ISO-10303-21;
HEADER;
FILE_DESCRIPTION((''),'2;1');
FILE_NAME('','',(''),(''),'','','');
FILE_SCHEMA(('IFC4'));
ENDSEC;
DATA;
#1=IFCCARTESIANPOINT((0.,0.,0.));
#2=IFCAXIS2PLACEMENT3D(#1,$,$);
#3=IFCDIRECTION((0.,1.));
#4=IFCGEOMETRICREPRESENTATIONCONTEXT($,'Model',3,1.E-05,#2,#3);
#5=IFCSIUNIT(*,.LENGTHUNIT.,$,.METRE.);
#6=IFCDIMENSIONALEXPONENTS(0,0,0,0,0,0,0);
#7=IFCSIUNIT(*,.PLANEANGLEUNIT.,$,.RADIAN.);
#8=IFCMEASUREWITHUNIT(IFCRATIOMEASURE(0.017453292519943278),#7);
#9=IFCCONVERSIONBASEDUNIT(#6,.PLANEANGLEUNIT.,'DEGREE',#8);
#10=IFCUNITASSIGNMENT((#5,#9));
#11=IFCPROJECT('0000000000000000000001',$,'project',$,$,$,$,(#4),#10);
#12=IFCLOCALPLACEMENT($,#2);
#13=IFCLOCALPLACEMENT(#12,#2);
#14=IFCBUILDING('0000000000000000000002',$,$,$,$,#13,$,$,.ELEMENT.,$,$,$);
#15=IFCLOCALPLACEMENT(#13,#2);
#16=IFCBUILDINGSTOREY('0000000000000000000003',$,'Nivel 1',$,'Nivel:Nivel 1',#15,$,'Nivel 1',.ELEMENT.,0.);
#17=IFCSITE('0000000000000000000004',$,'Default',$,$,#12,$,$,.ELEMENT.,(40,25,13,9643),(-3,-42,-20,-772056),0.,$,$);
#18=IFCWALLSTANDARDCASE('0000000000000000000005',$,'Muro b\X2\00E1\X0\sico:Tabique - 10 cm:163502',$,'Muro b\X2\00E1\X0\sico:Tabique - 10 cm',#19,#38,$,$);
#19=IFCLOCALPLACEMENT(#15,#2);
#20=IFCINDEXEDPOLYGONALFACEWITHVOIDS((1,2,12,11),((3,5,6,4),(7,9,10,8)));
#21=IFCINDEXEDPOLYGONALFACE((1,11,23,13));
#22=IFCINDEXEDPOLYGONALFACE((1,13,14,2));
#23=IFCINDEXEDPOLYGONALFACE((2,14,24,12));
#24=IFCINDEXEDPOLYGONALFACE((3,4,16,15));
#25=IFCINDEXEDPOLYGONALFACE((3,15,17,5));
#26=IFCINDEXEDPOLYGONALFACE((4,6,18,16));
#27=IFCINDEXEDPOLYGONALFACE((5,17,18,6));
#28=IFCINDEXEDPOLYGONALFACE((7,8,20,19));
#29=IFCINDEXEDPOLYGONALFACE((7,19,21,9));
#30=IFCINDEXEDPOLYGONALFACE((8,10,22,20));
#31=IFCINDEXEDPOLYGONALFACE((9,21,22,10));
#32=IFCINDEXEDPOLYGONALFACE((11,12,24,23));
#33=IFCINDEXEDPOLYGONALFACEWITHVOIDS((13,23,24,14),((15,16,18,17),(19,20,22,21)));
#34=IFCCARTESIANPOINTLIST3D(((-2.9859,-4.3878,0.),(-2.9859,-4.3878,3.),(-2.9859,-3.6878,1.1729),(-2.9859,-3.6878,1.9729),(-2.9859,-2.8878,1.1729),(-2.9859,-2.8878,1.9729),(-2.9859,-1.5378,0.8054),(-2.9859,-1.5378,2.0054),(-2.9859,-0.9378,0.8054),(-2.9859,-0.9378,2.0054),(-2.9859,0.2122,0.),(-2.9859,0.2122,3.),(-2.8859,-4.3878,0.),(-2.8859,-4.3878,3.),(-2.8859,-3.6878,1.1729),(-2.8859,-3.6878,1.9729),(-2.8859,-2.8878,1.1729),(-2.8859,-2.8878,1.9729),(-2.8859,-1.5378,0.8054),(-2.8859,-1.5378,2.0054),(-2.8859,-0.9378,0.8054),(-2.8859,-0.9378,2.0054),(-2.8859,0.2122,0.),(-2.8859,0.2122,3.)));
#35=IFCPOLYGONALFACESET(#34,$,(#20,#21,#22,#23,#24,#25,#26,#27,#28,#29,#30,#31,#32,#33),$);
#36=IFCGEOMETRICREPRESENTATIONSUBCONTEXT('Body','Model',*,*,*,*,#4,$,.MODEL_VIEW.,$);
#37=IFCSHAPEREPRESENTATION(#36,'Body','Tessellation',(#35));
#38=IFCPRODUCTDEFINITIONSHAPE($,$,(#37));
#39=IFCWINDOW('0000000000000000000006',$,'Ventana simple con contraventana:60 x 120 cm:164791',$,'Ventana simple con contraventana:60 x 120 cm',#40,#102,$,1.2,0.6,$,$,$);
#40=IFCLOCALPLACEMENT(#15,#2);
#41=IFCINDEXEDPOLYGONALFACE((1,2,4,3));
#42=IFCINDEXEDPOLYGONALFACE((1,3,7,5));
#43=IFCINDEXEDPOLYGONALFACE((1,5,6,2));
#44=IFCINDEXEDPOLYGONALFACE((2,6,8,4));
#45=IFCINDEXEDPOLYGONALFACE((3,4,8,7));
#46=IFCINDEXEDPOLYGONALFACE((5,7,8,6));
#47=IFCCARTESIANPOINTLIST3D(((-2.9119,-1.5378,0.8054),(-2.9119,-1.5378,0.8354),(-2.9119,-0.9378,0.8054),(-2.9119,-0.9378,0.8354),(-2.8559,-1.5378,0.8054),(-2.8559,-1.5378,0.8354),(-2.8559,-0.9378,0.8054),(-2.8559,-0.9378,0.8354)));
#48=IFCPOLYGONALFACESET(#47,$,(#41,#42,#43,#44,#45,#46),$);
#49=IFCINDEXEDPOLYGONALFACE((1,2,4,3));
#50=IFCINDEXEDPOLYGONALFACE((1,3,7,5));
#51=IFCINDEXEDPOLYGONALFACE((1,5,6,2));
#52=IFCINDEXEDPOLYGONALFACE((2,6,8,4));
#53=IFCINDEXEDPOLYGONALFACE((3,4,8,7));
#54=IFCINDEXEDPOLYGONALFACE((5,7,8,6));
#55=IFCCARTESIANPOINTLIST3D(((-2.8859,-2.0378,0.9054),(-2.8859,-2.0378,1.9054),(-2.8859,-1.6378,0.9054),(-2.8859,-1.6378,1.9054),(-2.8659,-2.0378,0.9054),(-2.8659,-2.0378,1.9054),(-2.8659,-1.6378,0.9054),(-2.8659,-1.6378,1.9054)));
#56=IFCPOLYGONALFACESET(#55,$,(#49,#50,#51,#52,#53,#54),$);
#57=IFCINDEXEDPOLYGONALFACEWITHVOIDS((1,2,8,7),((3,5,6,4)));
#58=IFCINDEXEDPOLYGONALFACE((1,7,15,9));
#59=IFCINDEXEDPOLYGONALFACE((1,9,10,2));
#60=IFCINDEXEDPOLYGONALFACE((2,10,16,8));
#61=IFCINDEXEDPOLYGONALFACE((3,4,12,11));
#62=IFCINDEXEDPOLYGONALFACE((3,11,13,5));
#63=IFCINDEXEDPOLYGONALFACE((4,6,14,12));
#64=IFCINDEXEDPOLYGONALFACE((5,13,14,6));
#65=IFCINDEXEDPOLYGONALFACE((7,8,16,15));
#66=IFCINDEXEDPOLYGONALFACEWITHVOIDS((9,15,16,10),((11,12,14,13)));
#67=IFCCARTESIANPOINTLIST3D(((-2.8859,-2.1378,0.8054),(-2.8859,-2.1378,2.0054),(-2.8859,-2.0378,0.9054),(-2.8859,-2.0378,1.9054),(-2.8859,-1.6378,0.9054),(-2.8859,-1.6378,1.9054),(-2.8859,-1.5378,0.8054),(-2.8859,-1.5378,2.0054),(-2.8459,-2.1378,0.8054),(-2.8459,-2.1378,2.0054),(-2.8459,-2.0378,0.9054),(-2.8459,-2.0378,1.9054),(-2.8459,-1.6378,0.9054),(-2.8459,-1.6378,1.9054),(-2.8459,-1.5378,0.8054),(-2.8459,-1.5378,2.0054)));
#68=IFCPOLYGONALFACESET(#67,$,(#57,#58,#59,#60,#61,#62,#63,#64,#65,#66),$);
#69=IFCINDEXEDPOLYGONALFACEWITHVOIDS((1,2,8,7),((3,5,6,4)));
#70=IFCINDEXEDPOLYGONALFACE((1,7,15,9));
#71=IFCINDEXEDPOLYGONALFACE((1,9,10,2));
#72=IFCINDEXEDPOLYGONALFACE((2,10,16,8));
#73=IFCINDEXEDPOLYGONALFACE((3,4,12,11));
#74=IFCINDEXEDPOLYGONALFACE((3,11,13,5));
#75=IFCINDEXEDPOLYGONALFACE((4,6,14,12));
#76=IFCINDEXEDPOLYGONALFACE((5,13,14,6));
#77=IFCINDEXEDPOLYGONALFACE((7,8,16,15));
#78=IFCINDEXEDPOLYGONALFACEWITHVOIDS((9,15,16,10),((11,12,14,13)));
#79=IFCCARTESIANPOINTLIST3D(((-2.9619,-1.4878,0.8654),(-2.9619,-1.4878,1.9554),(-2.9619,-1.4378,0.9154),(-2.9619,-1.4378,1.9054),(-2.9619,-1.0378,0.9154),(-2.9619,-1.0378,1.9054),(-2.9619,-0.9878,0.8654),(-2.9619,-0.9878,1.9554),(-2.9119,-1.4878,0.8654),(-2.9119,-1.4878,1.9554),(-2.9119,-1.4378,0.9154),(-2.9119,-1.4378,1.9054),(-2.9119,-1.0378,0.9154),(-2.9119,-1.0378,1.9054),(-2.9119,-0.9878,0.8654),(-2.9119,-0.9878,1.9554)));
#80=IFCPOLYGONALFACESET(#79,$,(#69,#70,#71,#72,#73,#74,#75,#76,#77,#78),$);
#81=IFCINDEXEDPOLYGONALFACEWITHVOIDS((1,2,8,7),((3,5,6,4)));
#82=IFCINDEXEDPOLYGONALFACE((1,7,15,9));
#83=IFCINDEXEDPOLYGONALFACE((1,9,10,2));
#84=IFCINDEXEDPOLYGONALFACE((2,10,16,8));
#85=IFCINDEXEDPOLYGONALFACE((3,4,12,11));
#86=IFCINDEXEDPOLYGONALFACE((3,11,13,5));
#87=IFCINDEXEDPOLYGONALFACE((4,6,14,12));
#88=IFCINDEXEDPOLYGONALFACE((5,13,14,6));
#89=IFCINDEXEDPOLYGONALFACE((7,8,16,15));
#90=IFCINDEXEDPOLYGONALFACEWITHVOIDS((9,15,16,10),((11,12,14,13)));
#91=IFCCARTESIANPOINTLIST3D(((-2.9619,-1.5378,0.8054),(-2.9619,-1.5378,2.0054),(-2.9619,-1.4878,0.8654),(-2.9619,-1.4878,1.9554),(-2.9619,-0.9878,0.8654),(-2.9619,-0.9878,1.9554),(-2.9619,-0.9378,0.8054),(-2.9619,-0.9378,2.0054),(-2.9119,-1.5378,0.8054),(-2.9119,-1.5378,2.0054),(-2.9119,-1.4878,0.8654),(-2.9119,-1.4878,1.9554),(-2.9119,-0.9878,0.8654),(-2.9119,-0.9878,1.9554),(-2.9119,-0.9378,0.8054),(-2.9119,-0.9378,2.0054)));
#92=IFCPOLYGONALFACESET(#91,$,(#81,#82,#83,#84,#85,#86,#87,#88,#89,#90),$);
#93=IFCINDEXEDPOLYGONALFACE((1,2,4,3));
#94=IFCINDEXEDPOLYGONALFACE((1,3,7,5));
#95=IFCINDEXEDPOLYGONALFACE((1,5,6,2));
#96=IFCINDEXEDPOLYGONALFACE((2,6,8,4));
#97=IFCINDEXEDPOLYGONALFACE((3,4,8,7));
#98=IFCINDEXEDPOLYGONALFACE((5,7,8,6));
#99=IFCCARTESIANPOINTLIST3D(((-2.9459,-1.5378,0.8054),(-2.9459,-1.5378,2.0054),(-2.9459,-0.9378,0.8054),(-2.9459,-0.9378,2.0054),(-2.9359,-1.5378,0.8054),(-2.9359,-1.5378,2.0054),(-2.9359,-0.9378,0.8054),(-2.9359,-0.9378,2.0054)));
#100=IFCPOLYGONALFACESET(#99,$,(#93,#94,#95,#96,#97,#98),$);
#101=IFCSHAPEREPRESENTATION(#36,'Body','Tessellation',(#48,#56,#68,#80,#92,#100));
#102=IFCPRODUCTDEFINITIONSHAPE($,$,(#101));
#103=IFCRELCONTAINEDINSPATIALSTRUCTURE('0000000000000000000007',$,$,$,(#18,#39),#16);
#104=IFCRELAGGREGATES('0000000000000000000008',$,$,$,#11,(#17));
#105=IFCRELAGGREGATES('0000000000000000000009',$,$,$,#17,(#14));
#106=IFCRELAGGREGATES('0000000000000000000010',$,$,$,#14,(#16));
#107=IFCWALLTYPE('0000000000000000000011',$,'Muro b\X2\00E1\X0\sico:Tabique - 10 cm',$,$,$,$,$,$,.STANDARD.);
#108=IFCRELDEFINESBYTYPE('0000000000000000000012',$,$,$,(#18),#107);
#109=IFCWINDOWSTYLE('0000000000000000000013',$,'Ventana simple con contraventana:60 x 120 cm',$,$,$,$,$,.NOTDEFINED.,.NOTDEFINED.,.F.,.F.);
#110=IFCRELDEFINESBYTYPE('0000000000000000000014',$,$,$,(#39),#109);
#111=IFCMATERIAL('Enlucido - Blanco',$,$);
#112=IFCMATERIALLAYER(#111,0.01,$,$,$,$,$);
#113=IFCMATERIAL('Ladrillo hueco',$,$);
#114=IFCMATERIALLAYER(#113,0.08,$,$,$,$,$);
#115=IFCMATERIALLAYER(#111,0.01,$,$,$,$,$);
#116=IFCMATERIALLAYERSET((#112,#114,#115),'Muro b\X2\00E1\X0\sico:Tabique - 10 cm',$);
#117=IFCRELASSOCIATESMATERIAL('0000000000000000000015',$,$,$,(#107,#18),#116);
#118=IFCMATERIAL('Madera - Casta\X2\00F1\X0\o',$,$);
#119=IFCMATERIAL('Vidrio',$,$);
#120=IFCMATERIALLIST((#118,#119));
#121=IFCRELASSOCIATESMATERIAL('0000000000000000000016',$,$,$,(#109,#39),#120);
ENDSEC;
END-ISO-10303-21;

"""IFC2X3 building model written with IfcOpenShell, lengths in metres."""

from ifc_helpers import new_model, entity, si_unit, converted_unit, direction, frame, frame_2d, origin, origin_2d_with_axis, place, context, subcontext, project, spatial, polyline, rectangle, outline, extrude, source, transform, mapped, material, material_list, layer, layer_set, layer_usage, type_object, type_shapes, element, fill, save


model = new_model("IFC2X3")

# Units and contexts
model_context = context("Model", 3, precision=1e-05, world=origin(), true_north=direction((0.0, 1.0)))
body_context = subcontext(model_context, "Body", "Model", "MODEL_VIEW")
ifc_project = project(units=[si_unit("LENGTHUNIT", "METRE"), converted_unit("PLANEANGLEUNIT", "DEGREE", entity("IfcRatioMeasure", 0.017453292519943278), si_unit("PLANEANGLEUNIT", "RADIAN"), dimensions=[0, 0, 0, 0, 0, 0, 0])], contexts=[model_context])

# Site, building, storey
site_placement = place(None, origin())
site = spatial("IfcSite", under=ifc_project, at=site_placement, Name="Default", CompositionType="ELEMENT", RefLatitude=(40, 25, 13, 9643), RefLongitude=(-3, -42, -20, -772056), RefElevation=0.0)
building_placement = place(site_placement, origin())
building = spatial("IfcBuilding", under=site, at=building_placement, CompositionType="ELEMENT")
storey_placement = place(building_placement, origin())
storey = spatial("IfcBuildingStorey", under=building, at=storey_placement, Name="Nivel 1", ObjectType="Nivel:Nivel 1", LongName="Nivel 1", CompositionType="ELEMENT", Elevation=0.0)

# Shared definitions
ifc_material_1 = material(Name="Ladrillo hueco")
ifc_material_2 = material(Name="Enlucido - Blanco")

# Wall, openings, window
ifc_layer_1 = layer(ifc_material_2, 0.01)
ifc_layer_2 = layer(ifc_material_1, 0.08)
ifc_layer_3 = layer(ifc_material_2, 0.01)
ifc_layer_set_1 = layer_set([ifc_layer_1, ifc_layer_2, ifc_layer_3], Name="Muro básico:Tabique - 10 cm")
ifc_layer_usage_1 = layer_usage(ifc_layer_set_1, "AXIS2", "NEGATIVE", 0.05)
wall_type_1 = type_object("IfcWallType", Name="Muro básico:Tabique - 10 cm", PredefinedType="STANDARD", material=ifc_layer_set_1)
wall_1_placement = place(storey_placement, frame((-2.9359, 0.2122, 0.0), z_axis=(0.0, 0.0, 1.0), x_axis=(0.0, -1.0, 0.0)))
wall_1 = element("IfcWallStandardCase", 1, at=wall_1_placement, inside=storey, type_object=wall_type_1, material=ifc_layer_usage_1, Name="Muro básico:Tabique - 10 cm:163502", ObjectType="Muro básico:Tabique - 10 cm", context=body_context, shape_type="SweptSolid", body=[
    extrude(rectangle(XDim=4.6, YDim=0.1, at=frame_2d((2.3, 0.0), x_axis=(-1.0, 0.0))), origin(), (0.0, 0.0, 1.0), 3.0),
])
opening_1_placement = place(wall_1_placement, frame((3.1, -0.05, 1.1729)))
element("IfcOpeningElement", 2, at=opening_1_placement, cuts=wall_1, ObjectType="Opening", context=body_context, shape_type="SweptSolid", body=[
    extrude(rectangle(XDim=0.8, YDim=0.8, at=frame_2d((0.4, 0.4), x_axis=(1.0, 0.0))), frame((0.0, 0.0, 0.0), z_axis=(0.0, 1.0, 0.0), x_axis=(0.0, 0.0, 1.0)), (0.0, 0.0, 1.0), 0.1),
])
opening_2_placement = place(wall_1_placement, frame((1.15, -0.05, 0.8054)))
opening_2 = element("IfcOpeningElement", 3, at=opening_2_placement, cuts=wall_1, ObjectType="Opening", context=body_context, shape_type="SweptSolid", body=[
    extrude(rectangle(XDim=1.2, YDim=0.6, at=frame_2d((0.6, 0.3), x_axis=(1.0, 0.0))), frame((0.0, 0.0, 0.0), z_axis=(0.0, 1.0, 0.0), x_axis=(0.0, 0.0, 1.0)), (0.0, 0.0, 1.0), 0.1),
])
ifc_material_3 = material(Name="Madera - Castaño")
ifc_material_4 = material(Name="Vidrio")
ifc_material_list = material_list([ifc_material_3, ifc_material_4])
window_style = type_object("IfcWindowStyle", Name="Ventana simple con contraventana:60 x 120 cm", ConstructionType="NOTDEFINED", OperationType="NOTDEFINED", ParameterTakesPrecedence=False, Sizeable=False, material=ifc_material_list)
shared_shape_1 = source(origin(), body_context, "Body", "SweptSolid", [
    extrude(rectangle(XDim=0.6, YDim=0.056, at=frame_2d((0.0, 0.0), x_axis=(1.0, 0.0))), frame((0.3, 0.102, 0.0)), (0.0, 0.0, 1.0), 0.03),
    extrude(rectangle(XDim=0.02, YDim=0.4, at=frame_2d((0.0, 0.0), x_axis=(1.0, 0.0))), frame((0.9, 0.11, 0.1), z_axis=(0.0, 0.0, 1.0), x_axis=(0.0, 1.0, 0.0)), (0.0, 0.0, 1.0), 1.0),
    extrude(outline(polyline([(-0.6, -0.3), (0.6, -0.3), (0.6, 0.3), (-0.6, 0.3), (-0.6, -0.3)]), holes=[polyline([(-0.5, 0.2), (0.5, 0.2), (0.5, -0.2), (-0.5, -0.2), (-0.5, 0.2)])]), frame((0.9, 0.1, 0.6), z_axis=(0.0, 1.0, 0.0), x_axis=(0.0, 0.0, -1.0)), (0.0, 0.0, 1.0), 0.04),
    extrude(outline(polyline([(-0.545, -0.25), (0.545, -0.25), (0.545, 0.25), (-0.545, 0.25), (-0.545, -0.25)]), holes=[polyline([(-0.495, -0.2), (-0.495, 0.2), (0.495, 0.2), (0.495, -0.2), (-0.495, -0.2)])]), frame((0.3, 0.024, 0.605), z_axis=(0.0, 1.0, 0.0), x_axis=(0.0, 0.0, -1.0)), (0.0, 0.0, 1.0), 0.05),
    extrude(outline(polyline([(-0.3, -0.6), (0.3, -0.6), (0.3, 0.6), (-0.3, 0.6), (-0.3, -0.6)]), holes=[polyline([(-0.25, -0.55), (-0.25, 0.54), (0.25, 0.54), (0.25, -0.55), (-0.25, -0.55)])]), frame((0.3, 0.024, 0.6), z_axis=(0.0, 1.0, 0.0), x_axis=(1.0, 0.0, 0.0)), (0.0, 0.0, 1.0), 0.05),
    extrude(rectangle(XDim=0.01, YDim=0.6, at=origin_2d_with_axis()), frame((0.3, 0.045, 0.0), z_axis=(0.0, 0.0, 1.0), x_axis=(0.0, 1.0, 0.0)), (0.0, 0.0, 1.0), 1.2),
])
type_shapes(window_style, [shared_shape_1])
window_placement = place(opening_2_placement, origin())
window = element("IfcWindow", 4, at=window_placement, inside=storey, type_object=window_style, material=ifc_material_list, Name="Ventana simple con contraventana:60 x 120 cm:164791", ObjectType="Ventana simple con contraventana:60 x 120 cm", OverallHeight=1.2, OverallWidth=0.6, context=body_context, shape_type="MappedRepresentation", body=[
    mapped(shared_shape_1, transform((0.0, 0.0, 0.0), scale=1.0)),
])
fill(opening_2, window)

save(model, "model.ifc")
